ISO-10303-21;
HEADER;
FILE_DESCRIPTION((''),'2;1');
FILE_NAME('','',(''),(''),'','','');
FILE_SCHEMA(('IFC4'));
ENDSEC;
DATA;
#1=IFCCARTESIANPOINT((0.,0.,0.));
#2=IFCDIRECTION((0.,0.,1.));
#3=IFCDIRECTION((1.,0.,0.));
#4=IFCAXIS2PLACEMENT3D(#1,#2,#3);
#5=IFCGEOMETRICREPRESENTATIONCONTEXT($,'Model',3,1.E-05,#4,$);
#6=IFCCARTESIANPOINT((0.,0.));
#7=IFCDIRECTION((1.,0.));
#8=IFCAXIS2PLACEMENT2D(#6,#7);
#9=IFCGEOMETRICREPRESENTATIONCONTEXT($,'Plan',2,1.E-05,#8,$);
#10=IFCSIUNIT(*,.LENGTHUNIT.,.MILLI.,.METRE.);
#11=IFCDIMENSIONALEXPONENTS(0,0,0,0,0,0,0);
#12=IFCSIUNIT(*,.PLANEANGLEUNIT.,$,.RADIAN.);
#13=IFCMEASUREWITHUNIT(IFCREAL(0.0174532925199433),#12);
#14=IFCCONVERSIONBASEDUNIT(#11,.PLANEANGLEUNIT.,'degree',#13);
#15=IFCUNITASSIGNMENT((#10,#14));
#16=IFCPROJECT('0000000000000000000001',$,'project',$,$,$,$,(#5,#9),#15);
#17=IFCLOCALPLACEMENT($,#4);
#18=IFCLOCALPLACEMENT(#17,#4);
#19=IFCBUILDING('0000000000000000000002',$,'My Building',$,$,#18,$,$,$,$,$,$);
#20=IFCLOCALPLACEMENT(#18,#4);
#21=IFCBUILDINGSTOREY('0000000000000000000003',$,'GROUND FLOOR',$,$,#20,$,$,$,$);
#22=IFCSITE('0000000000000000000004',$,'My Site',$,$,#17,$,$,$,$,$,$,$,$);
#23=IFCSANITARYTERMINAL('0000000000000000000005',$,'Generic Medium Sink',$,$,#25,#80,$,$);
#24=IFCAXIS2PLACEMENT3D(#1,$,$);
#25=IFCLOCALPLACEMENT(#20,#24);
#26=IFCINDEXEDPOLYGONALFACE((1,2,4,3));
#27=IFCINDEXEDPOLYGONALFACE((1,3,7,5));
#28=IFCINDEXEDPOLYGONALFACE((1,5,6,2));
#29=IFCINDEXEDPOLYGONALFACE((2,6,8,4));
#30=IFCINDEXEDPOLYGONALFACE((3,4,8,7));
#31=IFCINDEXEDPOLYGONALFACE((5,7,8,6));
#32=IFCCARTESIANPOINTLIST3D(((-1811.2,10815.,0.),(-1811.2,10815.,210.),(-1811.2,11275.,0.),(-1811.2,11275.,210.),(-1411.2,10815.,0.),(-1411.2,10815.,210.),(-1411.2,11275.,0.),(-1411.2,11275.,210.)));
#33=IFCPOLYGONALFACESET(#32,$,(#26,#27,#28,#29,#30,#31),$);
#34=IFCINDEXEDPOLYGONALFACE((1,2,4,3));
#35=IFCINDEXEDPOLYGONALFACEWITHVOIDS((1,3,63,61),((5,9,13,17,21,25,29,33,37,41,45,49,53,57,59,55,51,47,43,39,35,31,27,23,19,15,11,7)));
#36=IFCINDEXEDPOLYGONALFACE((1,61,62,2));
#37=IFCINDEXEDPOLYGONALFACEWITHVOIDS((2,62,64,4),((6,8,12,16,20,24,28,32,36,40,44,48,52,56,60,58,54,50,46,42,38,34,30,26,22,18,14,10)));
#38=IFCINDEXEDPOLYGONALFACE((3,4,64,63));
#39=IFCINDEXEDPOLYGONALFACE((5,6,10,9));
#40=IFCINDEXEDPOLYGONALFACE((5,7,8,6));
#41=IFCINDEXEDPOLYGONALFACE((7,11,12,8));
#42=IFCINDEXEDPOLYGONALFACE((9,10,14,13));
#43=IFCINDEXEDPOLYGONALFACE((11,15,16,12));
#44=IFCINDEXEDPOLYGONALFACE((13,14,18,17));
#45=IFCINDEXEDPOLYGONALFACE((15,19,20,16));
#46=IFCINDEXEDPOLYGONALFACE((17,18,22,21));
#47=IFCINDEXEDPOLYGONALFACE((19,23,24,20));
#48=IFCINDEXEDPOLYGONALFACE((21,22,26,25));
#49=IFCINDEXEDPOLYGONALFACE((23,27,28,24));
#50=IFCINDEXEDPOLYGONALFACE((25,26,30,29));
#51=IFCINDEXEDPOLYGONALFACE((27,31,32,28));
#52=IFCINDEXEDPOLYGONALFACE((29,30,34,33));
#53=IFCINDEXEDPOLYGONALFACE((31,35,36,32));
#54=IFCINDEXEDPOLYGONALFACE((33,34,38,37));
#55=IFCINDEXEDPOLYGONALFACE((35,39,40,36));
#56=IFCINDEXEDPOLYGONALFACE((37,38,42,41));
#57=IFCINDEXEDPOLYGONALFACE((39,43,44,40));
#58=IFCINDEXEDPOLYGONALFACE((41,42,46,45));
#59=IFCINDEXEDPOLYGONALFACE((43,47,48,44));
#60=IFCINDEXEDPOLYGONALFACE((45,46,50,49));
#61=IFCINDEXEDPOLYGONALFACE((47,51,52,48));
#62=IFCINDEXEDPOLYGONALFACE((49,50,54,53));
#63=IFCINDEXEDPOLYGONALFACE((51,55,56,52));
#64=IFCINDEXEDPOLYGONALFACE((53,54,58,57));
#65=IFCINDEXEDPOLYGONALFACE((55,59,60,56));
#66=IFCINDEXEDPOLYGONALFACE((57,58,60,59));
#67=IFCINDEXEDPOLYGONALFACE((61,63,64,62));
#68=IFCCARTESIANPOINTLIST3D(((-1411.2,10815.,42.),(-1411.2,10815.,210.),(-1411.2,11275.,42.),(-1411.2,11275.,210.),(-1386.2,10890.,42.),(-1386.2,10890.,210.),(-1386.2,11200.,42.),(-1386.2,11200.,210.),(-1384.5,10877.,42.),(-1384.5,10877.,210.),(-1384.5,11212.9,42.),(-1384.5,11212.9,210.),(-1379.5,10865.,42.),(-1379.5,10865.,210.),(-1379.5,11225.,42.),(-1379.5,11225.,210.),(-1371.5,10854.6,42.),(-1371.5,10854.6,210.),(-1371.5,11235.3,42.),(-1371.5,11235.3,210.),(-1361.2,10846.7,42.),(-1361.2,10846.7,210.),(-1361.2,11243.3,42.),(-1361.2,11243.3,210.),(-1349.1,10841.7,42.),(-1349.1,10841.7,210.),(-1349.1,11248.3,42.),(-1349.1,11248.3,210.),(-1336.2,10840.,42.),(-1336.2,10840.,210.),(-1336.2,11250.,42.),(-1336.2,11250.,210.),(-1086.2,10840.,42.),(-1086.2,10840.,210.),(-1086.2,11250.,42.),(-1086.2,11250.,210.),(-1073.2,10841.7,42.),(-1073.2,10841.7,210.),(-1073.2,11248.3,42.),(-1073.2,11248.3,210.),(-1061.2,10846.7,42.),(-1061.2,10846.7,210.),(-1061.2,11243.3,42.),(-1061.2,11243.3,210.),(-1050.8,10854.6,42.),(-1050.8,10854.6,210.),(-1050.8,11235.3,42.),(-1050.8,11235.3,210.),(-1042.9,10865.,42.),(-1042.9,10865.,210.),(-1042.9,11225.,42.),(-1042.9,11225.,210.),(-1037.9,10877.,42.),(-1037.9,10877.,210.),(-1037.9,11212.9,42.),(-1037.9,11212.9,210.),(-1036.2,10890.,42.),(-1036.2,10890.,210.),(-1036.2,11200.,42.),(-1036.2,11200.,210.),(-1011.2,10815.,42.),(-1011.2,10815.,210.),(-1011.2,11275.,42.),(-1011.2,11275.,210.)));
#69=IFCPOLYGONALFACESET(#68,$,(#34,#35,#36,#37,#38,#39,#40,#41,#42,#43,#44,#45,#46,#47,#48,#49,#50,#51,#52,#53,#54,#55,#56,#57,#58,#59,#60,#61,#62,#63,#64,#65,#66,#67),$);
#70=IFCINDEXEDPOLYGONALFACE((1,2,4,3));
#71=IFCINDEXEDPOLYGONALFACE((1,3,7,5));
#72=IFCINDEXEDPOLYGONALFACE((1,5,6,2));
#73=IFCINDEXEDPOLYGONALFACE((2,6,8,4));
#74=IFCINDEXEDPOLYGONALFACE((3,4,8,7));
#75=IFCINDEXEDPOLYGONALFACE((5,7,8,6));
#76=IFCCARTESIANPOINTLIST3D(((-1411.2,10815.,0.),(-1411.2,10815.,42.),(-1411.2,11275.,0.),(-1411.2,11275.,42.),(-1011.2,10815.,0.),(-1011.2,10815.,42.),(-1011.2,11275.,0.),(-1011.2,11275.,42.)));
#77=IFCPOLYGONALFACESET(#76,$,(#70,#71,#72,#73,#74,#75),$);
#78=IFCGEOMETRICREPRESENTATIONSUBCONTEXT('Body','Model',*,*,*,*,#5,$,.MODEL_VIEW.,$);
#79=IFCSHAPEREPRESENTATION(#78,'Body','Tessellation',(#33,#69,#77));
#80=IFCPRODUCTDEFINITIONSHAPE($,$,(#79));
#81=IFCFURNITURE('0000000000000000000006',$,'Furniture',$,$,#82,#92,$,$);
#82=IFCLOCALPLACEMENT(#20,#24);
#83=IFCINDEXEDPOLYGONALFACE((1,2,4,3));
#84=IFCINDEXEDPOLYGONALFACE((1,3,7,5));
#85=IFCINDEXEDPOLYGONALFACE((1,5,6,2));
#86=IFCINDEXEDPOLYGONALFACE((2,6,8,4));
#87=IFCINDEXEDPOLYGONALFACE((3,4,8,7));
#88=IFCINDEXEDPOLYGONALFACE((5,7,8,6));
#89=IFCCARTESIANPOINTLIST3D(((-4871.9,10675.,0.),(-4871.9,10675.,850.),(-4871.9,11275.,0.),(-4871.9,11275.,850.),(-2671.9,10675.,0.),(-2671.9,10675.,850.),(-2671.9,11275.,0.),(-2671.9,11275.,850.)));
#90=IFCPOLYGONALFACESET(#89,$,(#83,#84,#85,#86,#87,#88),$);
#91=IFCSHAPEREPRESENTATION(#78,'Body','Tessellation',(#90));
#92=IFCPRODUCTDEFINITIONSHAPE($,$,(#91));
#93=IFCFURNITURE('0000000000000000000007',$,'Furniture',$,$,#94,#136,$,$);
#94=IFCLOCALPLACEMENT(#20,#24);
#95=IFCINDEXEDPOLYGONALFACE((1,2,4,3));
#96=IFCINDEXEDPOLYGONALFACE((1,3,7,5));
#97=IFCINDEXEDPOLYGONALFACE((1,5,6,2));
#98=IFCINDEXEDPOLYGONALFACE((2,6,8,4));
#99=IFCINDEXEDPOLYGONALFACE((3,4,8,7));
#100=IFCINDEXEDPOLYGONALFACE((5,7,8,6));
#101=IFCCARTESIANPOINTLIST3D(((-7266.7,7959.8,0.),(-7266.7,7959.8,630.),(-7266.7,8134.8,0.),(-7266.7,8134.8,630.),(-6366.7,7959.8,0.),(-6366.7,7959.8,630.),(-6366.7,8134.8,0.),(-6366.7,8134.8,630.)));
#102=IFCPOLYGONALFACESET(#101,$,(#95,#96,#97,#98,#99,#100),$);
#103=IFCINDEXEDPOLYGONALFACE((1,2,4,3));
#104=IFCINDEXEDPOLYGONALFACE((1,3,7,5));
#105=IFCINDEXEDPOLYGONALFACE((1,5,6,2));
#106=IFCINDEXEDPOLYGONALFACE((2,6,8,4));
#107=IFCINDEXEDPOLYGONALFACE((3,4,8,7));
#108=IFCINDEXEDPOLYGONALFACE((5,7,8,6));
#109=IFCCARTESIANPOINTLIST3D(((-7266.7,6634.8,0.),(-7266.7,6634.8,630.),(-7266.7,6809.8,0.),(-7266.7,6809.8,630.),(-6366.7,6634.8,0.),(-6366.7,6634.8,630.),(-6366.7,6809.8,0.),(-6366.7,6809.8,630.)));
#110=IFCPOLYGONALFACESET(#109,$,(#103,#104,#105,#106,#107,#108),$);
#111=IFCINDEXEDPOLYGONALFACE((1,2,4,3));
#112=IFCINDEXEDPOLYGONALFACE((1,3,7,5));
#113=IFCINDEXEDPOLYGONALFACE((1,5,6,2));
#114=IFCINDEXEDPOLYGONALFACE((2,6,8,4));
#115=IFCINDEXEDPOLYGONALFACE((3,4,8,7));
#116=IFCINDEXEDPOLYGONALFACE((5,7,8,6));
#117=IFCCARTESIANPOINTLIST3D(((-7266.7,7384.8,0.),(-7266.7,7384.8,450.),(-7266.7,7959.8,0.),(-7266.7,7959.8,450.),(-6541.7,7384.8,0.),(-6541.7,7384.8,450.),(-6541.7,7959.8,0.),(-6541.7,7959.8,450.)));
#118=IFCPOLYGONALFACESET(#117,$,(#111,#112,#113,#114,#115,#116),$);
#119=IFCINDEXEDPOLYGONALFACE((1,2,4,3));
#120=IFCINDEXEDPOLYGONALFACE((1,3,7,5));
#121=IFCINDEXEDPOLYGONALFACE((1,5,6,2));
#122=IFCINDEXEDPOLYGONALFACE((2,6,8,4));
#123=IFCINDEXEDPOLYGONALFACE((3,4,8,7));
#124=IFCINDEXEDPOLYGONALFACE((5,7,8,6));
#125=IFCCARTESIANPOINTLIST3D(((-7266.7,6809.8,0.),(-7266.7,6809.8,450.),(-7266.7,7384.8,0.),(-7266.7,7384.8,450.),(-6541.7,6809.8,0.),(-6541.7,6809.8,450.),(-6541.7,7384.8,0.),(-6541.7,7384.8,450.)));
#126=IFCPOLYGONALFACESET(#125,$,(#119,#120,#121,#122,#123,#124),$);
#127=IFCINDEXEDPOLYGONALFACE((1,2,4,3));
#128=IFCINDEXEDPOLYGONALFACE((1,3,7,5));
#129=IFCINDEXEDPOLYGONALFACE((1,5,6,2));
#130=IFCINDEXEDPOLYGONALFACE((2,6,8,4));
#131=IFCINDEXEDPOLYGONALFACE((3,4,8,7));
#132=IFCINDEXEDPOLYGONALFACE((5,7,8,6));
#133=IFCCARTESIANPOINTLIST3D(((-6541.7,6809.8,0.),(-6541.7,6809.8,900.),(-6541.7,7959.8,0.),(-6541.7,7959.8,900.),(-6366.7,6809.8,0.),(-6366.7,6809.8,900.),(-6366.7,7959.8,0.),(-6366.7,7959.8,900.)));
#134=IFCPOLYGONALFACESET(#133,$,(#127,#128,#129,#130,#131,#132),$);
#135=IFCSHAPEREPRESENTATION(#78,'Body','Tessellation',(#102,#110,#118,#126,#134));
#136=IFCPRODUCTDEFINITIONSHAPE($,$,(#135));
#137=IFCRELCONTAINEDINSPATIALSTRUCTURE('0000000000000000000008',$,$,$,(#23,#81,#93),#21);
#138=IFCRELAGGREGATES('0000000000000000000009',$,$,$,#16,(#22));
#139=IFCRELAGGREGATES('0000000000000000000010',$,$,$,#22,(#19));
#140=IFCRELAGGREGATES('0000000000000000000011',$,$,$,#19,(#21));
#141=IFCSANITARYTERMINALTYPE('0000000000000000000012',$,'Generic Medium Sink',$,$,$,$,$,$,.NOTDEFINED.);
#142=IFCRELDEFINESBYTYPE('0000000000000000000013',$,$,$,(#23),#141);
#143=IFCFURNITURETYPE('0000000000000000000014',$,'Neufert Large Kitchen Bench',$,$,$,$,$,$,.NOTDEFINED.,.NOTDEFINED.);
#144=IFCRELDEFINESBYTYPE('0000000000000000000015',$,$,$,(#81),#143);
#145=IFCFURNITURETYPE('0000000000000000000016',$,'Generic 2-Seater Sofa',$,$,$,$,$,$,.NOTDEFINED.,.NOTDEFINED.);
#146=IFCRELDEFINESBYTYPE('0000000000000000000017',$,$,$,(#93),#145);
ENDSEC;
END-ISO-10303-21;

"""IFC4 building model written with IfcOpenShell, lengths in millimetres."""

from ifc_helpers import new_model, entity, si_unit, converted_unit, frame, origin_with_axes, origin_2d_with_axis, place, context, subcontext, project, spatial, line, indexed_curve, outline, extrude, shape, source, transform, mapped, type_object, type_shapes, element, save


model = new_model("IFC4")

# Units and contexts
model_context = context("Model", 3, precision=1e-05, world=origin_with_axes())
plan_context = context("Plan", 2, precision=1e-05, world=origin_2d_with_axis())
body_context_1 = subcontext(model_context, "Body", "Model", "MODEL_VIEW")
body_context_2 = subcontext(plan_context, "Body", "Plan", "PLAN_VIEW")
ifc_project = project(units=[si_unit("LENGTHUNIT", "METRE", prefix="MILLI"), converted_unit("PLANEANGLEUNIT", "degree", entity("IfcReal", 0.0174532925199433), si_unit("PLANEANGLEUNIT", "RADIAN"), dimensions=[0, 0, 0, 0, 0, 0, 0])], contexts=[model_context, plan_context])

# Site, building, storey
site_placement = place(None, origin_with_axes())
site = spatial("IfcSite", under=ifc_project, at=site_placement, Name="My Site")
building_placement = place(site_placement, origin_with_axes())
building = spatial("IfcBuilding", under=site, at=building_placement, Name="My Building")
storey_placement = place(building_placement, origin_with_axes())
storey = spatial("IfcBuildingStorey", under=building, at=storey_placement, Name="GROUND FLOOR")

# Sanitary terminal
sanitary_terminal_type_1 = type_object("IfcSanitaryTerminalType", Name="Generic Medium Sink", PredefinedType="NOTDEFINED")
shared_indexed_poly_curve = entity("IfcIndexedPolyCurve", entity("IfcCartesianPointList2D", [[400.0, 0.0], [800.0, 0.0], [800.0, 460.0], [400.0, 460.0]]), [entity("IfcLineIndex", [1, 2]), entity("IfcLineIndex", [2, 3]), entity("IfcLineIndex", [3, 4]), entity("IfcLineIndex", [4, 1])])
shared_shape_1 = source(origin_with_axes(), body_context_1, "Body", "SweptSolid", [
    extrude(outline(indexed_curve([(0.0, 0.0), (400.0, 0.0), (400.0, 460.0), (0.0, 460.0)], segments=[line(1, 2), line(2, 3), line(3, 4), line(4, 1)])), frame((-400.0, -460.0, 0.0), z_axis=(0.0, 0.0, 1.0), x_axis=(1.0, 0.0, 0.0)), (0.0, 0.0, 1.0), 210.0),
    entity("IfcExtrudedAreaSolid", entity("IfcArbitraryProfileDefWithVoids", "AREA", None, shared_indexed_poly_curve, [entity("IfcIndexedPolyCurve", entity("IfcCartesianPointList2D", [[425.0, 75.0], [439.6, 39.6], [475.0, 25.0], [725.0, 25.0], [760.4, 39.6], [775.0, 75.0], [775.0, 385.0], [760.4, 420.4], [725.0, 435.0], [475.0, 435.0], [439.6, 420.4], [425.0, 385.0]]), [entity("IfcLineIndex", [12, 1]), entity("IfcArcIndex", [1, 2, 3]), entity("IfcLineIndex", [3, 4]), entity("IfcArcIndex", [4, 5, 6]), entity("IfcLineIndex", [6, 7]), entity("IfcArcIndex", [7, 8, 9]), entity("IfcLineIndex", [9, 10]), entity("IfcArcIndex", [10, 11, 12]), entity("IfcLineIndex", [12, 1])])]), entity("IfcAxis2Placement3D", entity("IfcCartesianPoint", [-400.0, -460.0, 42.0]), entity("IfcDirection", [0.0, 0.0, 1.0]), entity("IfcDirection", [1.0, 0.0, 0.0])), entity("IfcDirection", [0.0, 0.0, 1.0]), 168.0),
    entity("IfcExtrudedAreaSolid", entity("IfcArbitraryClosedProfileDef", "AREA", None, shared_indexed_poly_curve), entity("IfcAxis2Placement3D", entity("IfcCartesianPoint", [-400.0, -460.0, 0.0]), entity("IfcDirection", [0.0, 0.0, 1.0]), entity("IfcDirection", [1.0, 0.0, 0.0])), entity("IfcDirection", [0.0, 0.0, 1.0]), 42.0),
])
shared_shape_2 = source(origin_with_axes(), body_context_2, "Body", "Curve2D", [
    entity("IfcIndexedPolyCurve", entity("IfcCartesianPointList2D", [[-400.0, -460.0], [400.0, -460.0], [400.0, 0.0], [-400.0, 0.0]]), [entity("IfcLineIndex", [1, 2]), entity("IfcLineIndex", [2, 3]), entity("IfcLineIndex", [3, 4]), entity("IfcLineIndex", [4, 1])]),
    entity("IfcIndexedPolyCurve", entity("IfcCartesianPointList2D", [[25.0, -385.0], [39.6, -420.4], [75.0, -435.0], [325.0, -435.0], [360.4, -420.4], [375.0, -385.0], [375.0, -75.0], [360.4, -39.6], [325.0, -25.0], [75.0, -25.0], [39.6, -39.6], [25.0, -75.0]]), [entity("IfcLineIndex", [12, 1]), entity("IfcArcIndex", [1, 2, 3]), entity("IfcLineIndex", [3, 4]), entity("IfcArcIndex", [4, 5, 6]), entity("IfcLineIndex", [6, 7]), entity("IfcArcIndex", [7, 8, 9]), entity("IfcLineIndex", [9, 10]), entity("IfcArcIndex", [10, 11, 12]), entity("IfcLineIndex", [12, 1])]),
    entity("IfcCircle", entity("IfcAxis2Placement2D", entity("IfcCartesianPoint", [200.0, -125.0])), 25.0),
    entity("IfcIndexedPolyCurve", entity("IfcCartesianPointList2D", [[200.0, -12.5], [200.0, -132.5]]), [entity("IfcLineIndex", [1, 2])]),
])
type_shapes(sanitary_terminal_type_1, [shared_shape_1, shared_shape_2])
sanitary_terminal_1_placement = place(storey_placement, frame((-1411.2, 11275.0, 0.0), z_axis=(0.0, 0.0, 1.0), x_axis=(1.0, 0.0, 0.0)))
element("IfcSanitaryTerminal", 1, at=sanitary_terminal_1_placement, inside=storey, type_object=sanitary_terminal_type_1, Name="Generic Medium Sink", shapes=[
    shape(body_context_1, "Body", "MappedRepresentation", [mapped(shared_shape_1, transform((0.0, 0.0, 0.0), x_axis=(1.0, 0.0, 0.0), y_axis=(0.0, 1.0, 0.0), z_axis=(0.0, 0.0, 1.0), scale=1.0))]),
    shape(body_context_2, "Body", "MappedRepresentation", [mapped(shared_shape_2, transform((0.0, 0.0, 0.0), x_axis=(1.0, 0.0, 0.0), y_axis=(0.0, 1.0, 0.0), z_axis=(0.0, 0.0, 1.0), scale=1.0))]),
])

# Furniture
furniture_type_1 = type_object("IfcFurnitureType", Name="Neufert Large Kitchen Bench", AssemblyPlace="NOTDEFINED", PredefinedType="NOTDEFINED")
shared_shape_3 = source(origin_with_axes(), body_context_1, "Body", "SweptSolid", [
    extrude(outline(indexed_curve([(0.0, 0.0), (2200.0, 0.0), (2200.0, 600.0), (0.0, 600.0)], segments=[line(1, 2), line(2, 3), line(3, 4), line(4, 1)])), origin_with_axes(), (0.0, 0.0, 1.0), 850.0),
])
shared_shape_4 = source(origin_with_axes(), body_context_2, "Body", "Annotation2D", [
    entity("IfcGeometricCurveSet", [entity("IfcIndexedPolyCurve", entity("IfcCartesianPointList2D", [[0.0, 0.0], [3700.7, 0.0], [3700.7, 600.0], [0.0, 600.0]]), [entity("IfcLineIndex", [1, 2]), entity("IfcLineIndex", [2, 3]), entity("IfcLineIndex", [3, 4]), entity("IfcLineIndex", [4, 1])])]),
])
type_shapes(furniture_type_1, [shared_shape_3, shared_shape_4])
furniture_1_placement = place(storey_placement, frame((-2671.9, 11275.0, 0.0), z_axis=(0.0, 0.0, 1.0), x_axis=(-1.0, 0.0, 0.0)))
element("IfcFurniture", 2, at=furniture_1_placement, inside=storey, type_object=furniture_type_1, Name="Furniture", shapes=[
    shape(body_context_1, "Body", "MappedRepresentation", [mapped(shared_shape_3, transform((0.0, 0.0, 0.0), x_axis=(1.0, 0.0, 0.0), y_axis=(0.0, 1.0, 0.0), z_axis=(0.0, 0.0, 1.0), scale=1.0))]),
    shape(body_context_2, "Body", "MappedRepresentation", [mapped(shared_shape_4, transform((0.0, 0.0, 0.0), x_axis=(1.0, 0.0, 0.0), y_axis=(0.0, 1.0, 0.0), z_axis=(0.0, 0.0, 1.0), scale=1.0))]),
])
furniture_type_2 = type_object("IfcFurnitureType", Name="Generic 2-Seater Sofa", AssemblyPlace="NOTDEFINED", PredefinedType="NOTDEFINED")
shared_shape_5 = source(origin_with_axes(), body_context_1, "Body", "SweptSolid", [
    extrude(outline(indexed_curve([(0.0, 0.0), (175.0, 0.0), (175.0, 900.0), (0.0, 900.0)], segments=[line(1, 2), line(2, 3), line(3, 4), line(4, 1)])), frame((-750.0, -900.0, 0.0), z_axis=(0.0, 0.0, 1.0), x_axis=(1.0, 0.0, 0.0)), (0.0, 0.0, 1.0), 630.0),
    extrude(outline(indexed_curve([(0.0, 0.0), (175.0, 0.0), (175.0, 900.0), (0.0, 900.0)], segments=[line(1, 2), line(2, 3), line(3, 4), line(4, 1)])), frame((575.0, -900.0, 0.0), z_axis=(0.0, 0.0, 1.0), x_axis=(1.0, 0.0, 0.0)), (0.0, 0.0, 1.0), 630.0),
    extrude(outline(indexed_curve([(175.0, 0.0), (750.0, 0.0), (750.0, 725.0), (175.0, 725.0)], segments=[line(1, 2), line(2, 3), line(3, 4), line(4, 1)])), frame((-750.0, -900.0, 0.0), z_axis=(0.0, 0.0, 1.0), x_axis=(1.0, 0.0, 0.0)), (0.0, 0.0, 1.0), 450.0),
    extrude(outline(indexed_curve([(750.0, 0.0), (1325.0, 0.0), (1325.0, 725.0), (750.0, 725.0)], segments=[line(1, 2), line(2, 3), line(3, 4), line(4, 1)])), frame((-750.0, -900.0, 0.0), z_axis=(0.0, 0.0, 1.0), x_axis=(1.0, 0.0, 0.0)), (0.0, 0.0, 1.0), 450.0),
    extrude(outline(indexed_curve([(175.0, 725.0), (1325.0, 725.0), (1325.0, 900.0), (175.0, 900.0)], segments=[line(1, 2), line(2, 3), line(3, 4), line(4, 1)])), frame((-750.0, -900.0, 0.0), z_axis=(0.0, 0.0, 1.0), x_axis=(1.0, 0.0, 0.0)), (0.0, 0.0, 1.0), 900.0),
])
shared_shape_6 = source(origin_with_axes(), body_context_2, "Body", "Curve2D", [
    entity("IfcIndexedPolyCurve", entity("IfcCartesianPointList2D", [[-750.0, -900.0], [-575.0, -900.0], [-575.0, 0.0], [-750.0, 0.0]]), [entity("IfcLineIndex", [1, 2]), entity("IfcLineIndex", [2, 3]), entity("IfcLineIndex", [3, 4]), entity("IfcLineIndex", [4, 1])]),
    entity("IfcIndexedPolyCurve", entity("IfcCartesianPointList2D", [[575.0, -900.0], [750.0, -900.0], [750.0, 0.0], [575.0, 0.0]]), [entity("IfcLineIndex", [1, 2]), entity("IfcLineIndex", [2, 3]), entity("IfcLineIndex", [3, 4]), entity("IfcLineIndex", [4, 1])]),
    entity("IfcIndexedPolyCurve", entity("IfcCartesianPointList2D", [[-575.0, -900.0], [0.0, -900.0], [0.0, -175.0], [-575.0, -175.0]]), [entity("IfcLineIndex", [1, 2]), entity("IfcLineIndex", [2, 3]), entity("IfcLineIndex", [3, 4]), entity("IfcLineIndex", [4, 1])]),
    entity("IfcIndexedPolyCurve", entity("IfcCartesianPointList2D", [[0.0, -900.0], [575.0, -900.0], [575.0, -175.0], [0.0, -175.0]]), [entity("IfcLineIndex", [1, 2]), entity("IfcLineIndex", [2, 3]), entity("IfcLineIndex", [3, 4]), entity("IfcLineIndex", [4, 1])]),
    entity("IfcIndexedPolyCurve", entity("IfcCartesianPointList2D", [[-575.0, -175.0], [575.0, -175.0], [575.0, 0.0], [-575.0, 0.0]]), [entity("IfcLineIndex", [1, 2]), entity("IfcLineIndex", [2, 3]), entity("IfcLineIndex", [3, 4]), entity("IfcLineIndex", [4, 1])]),
])
type_shapes(furniture_type_2, [shared_shape_5, shared_shape_6])
furniture_2_placement = place(storey_placement, frame((-6366.7, 7384.8, 0.0), z_axis=(0.0, 0.0, 1.0), x_axis=(0.0, -1.0, 0.0)))
element("IfcFurniture", 3, at=furniture_2_placement, inside=storey, type_object=furniture_type_2, Name="Furniture", shapes=[
    shape(body_context_1, "Body", "MappedRepresentation", [mapped(shared_shape_5, transform((0.0, 0.0, 0.0), x_axis=(1.0, 0.0, 0.0), y_axis=(0.0, 1.0, 0.0), z_axis=(0.0, 0.0, 1.0), scale=1.0))]),
    shape(body_context_2, "Body", "MappedRepresentation", [mapped(shared_shape_6, transform((0.0, 0.0, 0.0), x_axis=(1.0, 0.0, 0.0), y_axis=(0.0, 1.0, 0.0), z_axis=(0.0, 0.0, 1.0), scale=1.0))]),
])

save(model, "model.ifc")
